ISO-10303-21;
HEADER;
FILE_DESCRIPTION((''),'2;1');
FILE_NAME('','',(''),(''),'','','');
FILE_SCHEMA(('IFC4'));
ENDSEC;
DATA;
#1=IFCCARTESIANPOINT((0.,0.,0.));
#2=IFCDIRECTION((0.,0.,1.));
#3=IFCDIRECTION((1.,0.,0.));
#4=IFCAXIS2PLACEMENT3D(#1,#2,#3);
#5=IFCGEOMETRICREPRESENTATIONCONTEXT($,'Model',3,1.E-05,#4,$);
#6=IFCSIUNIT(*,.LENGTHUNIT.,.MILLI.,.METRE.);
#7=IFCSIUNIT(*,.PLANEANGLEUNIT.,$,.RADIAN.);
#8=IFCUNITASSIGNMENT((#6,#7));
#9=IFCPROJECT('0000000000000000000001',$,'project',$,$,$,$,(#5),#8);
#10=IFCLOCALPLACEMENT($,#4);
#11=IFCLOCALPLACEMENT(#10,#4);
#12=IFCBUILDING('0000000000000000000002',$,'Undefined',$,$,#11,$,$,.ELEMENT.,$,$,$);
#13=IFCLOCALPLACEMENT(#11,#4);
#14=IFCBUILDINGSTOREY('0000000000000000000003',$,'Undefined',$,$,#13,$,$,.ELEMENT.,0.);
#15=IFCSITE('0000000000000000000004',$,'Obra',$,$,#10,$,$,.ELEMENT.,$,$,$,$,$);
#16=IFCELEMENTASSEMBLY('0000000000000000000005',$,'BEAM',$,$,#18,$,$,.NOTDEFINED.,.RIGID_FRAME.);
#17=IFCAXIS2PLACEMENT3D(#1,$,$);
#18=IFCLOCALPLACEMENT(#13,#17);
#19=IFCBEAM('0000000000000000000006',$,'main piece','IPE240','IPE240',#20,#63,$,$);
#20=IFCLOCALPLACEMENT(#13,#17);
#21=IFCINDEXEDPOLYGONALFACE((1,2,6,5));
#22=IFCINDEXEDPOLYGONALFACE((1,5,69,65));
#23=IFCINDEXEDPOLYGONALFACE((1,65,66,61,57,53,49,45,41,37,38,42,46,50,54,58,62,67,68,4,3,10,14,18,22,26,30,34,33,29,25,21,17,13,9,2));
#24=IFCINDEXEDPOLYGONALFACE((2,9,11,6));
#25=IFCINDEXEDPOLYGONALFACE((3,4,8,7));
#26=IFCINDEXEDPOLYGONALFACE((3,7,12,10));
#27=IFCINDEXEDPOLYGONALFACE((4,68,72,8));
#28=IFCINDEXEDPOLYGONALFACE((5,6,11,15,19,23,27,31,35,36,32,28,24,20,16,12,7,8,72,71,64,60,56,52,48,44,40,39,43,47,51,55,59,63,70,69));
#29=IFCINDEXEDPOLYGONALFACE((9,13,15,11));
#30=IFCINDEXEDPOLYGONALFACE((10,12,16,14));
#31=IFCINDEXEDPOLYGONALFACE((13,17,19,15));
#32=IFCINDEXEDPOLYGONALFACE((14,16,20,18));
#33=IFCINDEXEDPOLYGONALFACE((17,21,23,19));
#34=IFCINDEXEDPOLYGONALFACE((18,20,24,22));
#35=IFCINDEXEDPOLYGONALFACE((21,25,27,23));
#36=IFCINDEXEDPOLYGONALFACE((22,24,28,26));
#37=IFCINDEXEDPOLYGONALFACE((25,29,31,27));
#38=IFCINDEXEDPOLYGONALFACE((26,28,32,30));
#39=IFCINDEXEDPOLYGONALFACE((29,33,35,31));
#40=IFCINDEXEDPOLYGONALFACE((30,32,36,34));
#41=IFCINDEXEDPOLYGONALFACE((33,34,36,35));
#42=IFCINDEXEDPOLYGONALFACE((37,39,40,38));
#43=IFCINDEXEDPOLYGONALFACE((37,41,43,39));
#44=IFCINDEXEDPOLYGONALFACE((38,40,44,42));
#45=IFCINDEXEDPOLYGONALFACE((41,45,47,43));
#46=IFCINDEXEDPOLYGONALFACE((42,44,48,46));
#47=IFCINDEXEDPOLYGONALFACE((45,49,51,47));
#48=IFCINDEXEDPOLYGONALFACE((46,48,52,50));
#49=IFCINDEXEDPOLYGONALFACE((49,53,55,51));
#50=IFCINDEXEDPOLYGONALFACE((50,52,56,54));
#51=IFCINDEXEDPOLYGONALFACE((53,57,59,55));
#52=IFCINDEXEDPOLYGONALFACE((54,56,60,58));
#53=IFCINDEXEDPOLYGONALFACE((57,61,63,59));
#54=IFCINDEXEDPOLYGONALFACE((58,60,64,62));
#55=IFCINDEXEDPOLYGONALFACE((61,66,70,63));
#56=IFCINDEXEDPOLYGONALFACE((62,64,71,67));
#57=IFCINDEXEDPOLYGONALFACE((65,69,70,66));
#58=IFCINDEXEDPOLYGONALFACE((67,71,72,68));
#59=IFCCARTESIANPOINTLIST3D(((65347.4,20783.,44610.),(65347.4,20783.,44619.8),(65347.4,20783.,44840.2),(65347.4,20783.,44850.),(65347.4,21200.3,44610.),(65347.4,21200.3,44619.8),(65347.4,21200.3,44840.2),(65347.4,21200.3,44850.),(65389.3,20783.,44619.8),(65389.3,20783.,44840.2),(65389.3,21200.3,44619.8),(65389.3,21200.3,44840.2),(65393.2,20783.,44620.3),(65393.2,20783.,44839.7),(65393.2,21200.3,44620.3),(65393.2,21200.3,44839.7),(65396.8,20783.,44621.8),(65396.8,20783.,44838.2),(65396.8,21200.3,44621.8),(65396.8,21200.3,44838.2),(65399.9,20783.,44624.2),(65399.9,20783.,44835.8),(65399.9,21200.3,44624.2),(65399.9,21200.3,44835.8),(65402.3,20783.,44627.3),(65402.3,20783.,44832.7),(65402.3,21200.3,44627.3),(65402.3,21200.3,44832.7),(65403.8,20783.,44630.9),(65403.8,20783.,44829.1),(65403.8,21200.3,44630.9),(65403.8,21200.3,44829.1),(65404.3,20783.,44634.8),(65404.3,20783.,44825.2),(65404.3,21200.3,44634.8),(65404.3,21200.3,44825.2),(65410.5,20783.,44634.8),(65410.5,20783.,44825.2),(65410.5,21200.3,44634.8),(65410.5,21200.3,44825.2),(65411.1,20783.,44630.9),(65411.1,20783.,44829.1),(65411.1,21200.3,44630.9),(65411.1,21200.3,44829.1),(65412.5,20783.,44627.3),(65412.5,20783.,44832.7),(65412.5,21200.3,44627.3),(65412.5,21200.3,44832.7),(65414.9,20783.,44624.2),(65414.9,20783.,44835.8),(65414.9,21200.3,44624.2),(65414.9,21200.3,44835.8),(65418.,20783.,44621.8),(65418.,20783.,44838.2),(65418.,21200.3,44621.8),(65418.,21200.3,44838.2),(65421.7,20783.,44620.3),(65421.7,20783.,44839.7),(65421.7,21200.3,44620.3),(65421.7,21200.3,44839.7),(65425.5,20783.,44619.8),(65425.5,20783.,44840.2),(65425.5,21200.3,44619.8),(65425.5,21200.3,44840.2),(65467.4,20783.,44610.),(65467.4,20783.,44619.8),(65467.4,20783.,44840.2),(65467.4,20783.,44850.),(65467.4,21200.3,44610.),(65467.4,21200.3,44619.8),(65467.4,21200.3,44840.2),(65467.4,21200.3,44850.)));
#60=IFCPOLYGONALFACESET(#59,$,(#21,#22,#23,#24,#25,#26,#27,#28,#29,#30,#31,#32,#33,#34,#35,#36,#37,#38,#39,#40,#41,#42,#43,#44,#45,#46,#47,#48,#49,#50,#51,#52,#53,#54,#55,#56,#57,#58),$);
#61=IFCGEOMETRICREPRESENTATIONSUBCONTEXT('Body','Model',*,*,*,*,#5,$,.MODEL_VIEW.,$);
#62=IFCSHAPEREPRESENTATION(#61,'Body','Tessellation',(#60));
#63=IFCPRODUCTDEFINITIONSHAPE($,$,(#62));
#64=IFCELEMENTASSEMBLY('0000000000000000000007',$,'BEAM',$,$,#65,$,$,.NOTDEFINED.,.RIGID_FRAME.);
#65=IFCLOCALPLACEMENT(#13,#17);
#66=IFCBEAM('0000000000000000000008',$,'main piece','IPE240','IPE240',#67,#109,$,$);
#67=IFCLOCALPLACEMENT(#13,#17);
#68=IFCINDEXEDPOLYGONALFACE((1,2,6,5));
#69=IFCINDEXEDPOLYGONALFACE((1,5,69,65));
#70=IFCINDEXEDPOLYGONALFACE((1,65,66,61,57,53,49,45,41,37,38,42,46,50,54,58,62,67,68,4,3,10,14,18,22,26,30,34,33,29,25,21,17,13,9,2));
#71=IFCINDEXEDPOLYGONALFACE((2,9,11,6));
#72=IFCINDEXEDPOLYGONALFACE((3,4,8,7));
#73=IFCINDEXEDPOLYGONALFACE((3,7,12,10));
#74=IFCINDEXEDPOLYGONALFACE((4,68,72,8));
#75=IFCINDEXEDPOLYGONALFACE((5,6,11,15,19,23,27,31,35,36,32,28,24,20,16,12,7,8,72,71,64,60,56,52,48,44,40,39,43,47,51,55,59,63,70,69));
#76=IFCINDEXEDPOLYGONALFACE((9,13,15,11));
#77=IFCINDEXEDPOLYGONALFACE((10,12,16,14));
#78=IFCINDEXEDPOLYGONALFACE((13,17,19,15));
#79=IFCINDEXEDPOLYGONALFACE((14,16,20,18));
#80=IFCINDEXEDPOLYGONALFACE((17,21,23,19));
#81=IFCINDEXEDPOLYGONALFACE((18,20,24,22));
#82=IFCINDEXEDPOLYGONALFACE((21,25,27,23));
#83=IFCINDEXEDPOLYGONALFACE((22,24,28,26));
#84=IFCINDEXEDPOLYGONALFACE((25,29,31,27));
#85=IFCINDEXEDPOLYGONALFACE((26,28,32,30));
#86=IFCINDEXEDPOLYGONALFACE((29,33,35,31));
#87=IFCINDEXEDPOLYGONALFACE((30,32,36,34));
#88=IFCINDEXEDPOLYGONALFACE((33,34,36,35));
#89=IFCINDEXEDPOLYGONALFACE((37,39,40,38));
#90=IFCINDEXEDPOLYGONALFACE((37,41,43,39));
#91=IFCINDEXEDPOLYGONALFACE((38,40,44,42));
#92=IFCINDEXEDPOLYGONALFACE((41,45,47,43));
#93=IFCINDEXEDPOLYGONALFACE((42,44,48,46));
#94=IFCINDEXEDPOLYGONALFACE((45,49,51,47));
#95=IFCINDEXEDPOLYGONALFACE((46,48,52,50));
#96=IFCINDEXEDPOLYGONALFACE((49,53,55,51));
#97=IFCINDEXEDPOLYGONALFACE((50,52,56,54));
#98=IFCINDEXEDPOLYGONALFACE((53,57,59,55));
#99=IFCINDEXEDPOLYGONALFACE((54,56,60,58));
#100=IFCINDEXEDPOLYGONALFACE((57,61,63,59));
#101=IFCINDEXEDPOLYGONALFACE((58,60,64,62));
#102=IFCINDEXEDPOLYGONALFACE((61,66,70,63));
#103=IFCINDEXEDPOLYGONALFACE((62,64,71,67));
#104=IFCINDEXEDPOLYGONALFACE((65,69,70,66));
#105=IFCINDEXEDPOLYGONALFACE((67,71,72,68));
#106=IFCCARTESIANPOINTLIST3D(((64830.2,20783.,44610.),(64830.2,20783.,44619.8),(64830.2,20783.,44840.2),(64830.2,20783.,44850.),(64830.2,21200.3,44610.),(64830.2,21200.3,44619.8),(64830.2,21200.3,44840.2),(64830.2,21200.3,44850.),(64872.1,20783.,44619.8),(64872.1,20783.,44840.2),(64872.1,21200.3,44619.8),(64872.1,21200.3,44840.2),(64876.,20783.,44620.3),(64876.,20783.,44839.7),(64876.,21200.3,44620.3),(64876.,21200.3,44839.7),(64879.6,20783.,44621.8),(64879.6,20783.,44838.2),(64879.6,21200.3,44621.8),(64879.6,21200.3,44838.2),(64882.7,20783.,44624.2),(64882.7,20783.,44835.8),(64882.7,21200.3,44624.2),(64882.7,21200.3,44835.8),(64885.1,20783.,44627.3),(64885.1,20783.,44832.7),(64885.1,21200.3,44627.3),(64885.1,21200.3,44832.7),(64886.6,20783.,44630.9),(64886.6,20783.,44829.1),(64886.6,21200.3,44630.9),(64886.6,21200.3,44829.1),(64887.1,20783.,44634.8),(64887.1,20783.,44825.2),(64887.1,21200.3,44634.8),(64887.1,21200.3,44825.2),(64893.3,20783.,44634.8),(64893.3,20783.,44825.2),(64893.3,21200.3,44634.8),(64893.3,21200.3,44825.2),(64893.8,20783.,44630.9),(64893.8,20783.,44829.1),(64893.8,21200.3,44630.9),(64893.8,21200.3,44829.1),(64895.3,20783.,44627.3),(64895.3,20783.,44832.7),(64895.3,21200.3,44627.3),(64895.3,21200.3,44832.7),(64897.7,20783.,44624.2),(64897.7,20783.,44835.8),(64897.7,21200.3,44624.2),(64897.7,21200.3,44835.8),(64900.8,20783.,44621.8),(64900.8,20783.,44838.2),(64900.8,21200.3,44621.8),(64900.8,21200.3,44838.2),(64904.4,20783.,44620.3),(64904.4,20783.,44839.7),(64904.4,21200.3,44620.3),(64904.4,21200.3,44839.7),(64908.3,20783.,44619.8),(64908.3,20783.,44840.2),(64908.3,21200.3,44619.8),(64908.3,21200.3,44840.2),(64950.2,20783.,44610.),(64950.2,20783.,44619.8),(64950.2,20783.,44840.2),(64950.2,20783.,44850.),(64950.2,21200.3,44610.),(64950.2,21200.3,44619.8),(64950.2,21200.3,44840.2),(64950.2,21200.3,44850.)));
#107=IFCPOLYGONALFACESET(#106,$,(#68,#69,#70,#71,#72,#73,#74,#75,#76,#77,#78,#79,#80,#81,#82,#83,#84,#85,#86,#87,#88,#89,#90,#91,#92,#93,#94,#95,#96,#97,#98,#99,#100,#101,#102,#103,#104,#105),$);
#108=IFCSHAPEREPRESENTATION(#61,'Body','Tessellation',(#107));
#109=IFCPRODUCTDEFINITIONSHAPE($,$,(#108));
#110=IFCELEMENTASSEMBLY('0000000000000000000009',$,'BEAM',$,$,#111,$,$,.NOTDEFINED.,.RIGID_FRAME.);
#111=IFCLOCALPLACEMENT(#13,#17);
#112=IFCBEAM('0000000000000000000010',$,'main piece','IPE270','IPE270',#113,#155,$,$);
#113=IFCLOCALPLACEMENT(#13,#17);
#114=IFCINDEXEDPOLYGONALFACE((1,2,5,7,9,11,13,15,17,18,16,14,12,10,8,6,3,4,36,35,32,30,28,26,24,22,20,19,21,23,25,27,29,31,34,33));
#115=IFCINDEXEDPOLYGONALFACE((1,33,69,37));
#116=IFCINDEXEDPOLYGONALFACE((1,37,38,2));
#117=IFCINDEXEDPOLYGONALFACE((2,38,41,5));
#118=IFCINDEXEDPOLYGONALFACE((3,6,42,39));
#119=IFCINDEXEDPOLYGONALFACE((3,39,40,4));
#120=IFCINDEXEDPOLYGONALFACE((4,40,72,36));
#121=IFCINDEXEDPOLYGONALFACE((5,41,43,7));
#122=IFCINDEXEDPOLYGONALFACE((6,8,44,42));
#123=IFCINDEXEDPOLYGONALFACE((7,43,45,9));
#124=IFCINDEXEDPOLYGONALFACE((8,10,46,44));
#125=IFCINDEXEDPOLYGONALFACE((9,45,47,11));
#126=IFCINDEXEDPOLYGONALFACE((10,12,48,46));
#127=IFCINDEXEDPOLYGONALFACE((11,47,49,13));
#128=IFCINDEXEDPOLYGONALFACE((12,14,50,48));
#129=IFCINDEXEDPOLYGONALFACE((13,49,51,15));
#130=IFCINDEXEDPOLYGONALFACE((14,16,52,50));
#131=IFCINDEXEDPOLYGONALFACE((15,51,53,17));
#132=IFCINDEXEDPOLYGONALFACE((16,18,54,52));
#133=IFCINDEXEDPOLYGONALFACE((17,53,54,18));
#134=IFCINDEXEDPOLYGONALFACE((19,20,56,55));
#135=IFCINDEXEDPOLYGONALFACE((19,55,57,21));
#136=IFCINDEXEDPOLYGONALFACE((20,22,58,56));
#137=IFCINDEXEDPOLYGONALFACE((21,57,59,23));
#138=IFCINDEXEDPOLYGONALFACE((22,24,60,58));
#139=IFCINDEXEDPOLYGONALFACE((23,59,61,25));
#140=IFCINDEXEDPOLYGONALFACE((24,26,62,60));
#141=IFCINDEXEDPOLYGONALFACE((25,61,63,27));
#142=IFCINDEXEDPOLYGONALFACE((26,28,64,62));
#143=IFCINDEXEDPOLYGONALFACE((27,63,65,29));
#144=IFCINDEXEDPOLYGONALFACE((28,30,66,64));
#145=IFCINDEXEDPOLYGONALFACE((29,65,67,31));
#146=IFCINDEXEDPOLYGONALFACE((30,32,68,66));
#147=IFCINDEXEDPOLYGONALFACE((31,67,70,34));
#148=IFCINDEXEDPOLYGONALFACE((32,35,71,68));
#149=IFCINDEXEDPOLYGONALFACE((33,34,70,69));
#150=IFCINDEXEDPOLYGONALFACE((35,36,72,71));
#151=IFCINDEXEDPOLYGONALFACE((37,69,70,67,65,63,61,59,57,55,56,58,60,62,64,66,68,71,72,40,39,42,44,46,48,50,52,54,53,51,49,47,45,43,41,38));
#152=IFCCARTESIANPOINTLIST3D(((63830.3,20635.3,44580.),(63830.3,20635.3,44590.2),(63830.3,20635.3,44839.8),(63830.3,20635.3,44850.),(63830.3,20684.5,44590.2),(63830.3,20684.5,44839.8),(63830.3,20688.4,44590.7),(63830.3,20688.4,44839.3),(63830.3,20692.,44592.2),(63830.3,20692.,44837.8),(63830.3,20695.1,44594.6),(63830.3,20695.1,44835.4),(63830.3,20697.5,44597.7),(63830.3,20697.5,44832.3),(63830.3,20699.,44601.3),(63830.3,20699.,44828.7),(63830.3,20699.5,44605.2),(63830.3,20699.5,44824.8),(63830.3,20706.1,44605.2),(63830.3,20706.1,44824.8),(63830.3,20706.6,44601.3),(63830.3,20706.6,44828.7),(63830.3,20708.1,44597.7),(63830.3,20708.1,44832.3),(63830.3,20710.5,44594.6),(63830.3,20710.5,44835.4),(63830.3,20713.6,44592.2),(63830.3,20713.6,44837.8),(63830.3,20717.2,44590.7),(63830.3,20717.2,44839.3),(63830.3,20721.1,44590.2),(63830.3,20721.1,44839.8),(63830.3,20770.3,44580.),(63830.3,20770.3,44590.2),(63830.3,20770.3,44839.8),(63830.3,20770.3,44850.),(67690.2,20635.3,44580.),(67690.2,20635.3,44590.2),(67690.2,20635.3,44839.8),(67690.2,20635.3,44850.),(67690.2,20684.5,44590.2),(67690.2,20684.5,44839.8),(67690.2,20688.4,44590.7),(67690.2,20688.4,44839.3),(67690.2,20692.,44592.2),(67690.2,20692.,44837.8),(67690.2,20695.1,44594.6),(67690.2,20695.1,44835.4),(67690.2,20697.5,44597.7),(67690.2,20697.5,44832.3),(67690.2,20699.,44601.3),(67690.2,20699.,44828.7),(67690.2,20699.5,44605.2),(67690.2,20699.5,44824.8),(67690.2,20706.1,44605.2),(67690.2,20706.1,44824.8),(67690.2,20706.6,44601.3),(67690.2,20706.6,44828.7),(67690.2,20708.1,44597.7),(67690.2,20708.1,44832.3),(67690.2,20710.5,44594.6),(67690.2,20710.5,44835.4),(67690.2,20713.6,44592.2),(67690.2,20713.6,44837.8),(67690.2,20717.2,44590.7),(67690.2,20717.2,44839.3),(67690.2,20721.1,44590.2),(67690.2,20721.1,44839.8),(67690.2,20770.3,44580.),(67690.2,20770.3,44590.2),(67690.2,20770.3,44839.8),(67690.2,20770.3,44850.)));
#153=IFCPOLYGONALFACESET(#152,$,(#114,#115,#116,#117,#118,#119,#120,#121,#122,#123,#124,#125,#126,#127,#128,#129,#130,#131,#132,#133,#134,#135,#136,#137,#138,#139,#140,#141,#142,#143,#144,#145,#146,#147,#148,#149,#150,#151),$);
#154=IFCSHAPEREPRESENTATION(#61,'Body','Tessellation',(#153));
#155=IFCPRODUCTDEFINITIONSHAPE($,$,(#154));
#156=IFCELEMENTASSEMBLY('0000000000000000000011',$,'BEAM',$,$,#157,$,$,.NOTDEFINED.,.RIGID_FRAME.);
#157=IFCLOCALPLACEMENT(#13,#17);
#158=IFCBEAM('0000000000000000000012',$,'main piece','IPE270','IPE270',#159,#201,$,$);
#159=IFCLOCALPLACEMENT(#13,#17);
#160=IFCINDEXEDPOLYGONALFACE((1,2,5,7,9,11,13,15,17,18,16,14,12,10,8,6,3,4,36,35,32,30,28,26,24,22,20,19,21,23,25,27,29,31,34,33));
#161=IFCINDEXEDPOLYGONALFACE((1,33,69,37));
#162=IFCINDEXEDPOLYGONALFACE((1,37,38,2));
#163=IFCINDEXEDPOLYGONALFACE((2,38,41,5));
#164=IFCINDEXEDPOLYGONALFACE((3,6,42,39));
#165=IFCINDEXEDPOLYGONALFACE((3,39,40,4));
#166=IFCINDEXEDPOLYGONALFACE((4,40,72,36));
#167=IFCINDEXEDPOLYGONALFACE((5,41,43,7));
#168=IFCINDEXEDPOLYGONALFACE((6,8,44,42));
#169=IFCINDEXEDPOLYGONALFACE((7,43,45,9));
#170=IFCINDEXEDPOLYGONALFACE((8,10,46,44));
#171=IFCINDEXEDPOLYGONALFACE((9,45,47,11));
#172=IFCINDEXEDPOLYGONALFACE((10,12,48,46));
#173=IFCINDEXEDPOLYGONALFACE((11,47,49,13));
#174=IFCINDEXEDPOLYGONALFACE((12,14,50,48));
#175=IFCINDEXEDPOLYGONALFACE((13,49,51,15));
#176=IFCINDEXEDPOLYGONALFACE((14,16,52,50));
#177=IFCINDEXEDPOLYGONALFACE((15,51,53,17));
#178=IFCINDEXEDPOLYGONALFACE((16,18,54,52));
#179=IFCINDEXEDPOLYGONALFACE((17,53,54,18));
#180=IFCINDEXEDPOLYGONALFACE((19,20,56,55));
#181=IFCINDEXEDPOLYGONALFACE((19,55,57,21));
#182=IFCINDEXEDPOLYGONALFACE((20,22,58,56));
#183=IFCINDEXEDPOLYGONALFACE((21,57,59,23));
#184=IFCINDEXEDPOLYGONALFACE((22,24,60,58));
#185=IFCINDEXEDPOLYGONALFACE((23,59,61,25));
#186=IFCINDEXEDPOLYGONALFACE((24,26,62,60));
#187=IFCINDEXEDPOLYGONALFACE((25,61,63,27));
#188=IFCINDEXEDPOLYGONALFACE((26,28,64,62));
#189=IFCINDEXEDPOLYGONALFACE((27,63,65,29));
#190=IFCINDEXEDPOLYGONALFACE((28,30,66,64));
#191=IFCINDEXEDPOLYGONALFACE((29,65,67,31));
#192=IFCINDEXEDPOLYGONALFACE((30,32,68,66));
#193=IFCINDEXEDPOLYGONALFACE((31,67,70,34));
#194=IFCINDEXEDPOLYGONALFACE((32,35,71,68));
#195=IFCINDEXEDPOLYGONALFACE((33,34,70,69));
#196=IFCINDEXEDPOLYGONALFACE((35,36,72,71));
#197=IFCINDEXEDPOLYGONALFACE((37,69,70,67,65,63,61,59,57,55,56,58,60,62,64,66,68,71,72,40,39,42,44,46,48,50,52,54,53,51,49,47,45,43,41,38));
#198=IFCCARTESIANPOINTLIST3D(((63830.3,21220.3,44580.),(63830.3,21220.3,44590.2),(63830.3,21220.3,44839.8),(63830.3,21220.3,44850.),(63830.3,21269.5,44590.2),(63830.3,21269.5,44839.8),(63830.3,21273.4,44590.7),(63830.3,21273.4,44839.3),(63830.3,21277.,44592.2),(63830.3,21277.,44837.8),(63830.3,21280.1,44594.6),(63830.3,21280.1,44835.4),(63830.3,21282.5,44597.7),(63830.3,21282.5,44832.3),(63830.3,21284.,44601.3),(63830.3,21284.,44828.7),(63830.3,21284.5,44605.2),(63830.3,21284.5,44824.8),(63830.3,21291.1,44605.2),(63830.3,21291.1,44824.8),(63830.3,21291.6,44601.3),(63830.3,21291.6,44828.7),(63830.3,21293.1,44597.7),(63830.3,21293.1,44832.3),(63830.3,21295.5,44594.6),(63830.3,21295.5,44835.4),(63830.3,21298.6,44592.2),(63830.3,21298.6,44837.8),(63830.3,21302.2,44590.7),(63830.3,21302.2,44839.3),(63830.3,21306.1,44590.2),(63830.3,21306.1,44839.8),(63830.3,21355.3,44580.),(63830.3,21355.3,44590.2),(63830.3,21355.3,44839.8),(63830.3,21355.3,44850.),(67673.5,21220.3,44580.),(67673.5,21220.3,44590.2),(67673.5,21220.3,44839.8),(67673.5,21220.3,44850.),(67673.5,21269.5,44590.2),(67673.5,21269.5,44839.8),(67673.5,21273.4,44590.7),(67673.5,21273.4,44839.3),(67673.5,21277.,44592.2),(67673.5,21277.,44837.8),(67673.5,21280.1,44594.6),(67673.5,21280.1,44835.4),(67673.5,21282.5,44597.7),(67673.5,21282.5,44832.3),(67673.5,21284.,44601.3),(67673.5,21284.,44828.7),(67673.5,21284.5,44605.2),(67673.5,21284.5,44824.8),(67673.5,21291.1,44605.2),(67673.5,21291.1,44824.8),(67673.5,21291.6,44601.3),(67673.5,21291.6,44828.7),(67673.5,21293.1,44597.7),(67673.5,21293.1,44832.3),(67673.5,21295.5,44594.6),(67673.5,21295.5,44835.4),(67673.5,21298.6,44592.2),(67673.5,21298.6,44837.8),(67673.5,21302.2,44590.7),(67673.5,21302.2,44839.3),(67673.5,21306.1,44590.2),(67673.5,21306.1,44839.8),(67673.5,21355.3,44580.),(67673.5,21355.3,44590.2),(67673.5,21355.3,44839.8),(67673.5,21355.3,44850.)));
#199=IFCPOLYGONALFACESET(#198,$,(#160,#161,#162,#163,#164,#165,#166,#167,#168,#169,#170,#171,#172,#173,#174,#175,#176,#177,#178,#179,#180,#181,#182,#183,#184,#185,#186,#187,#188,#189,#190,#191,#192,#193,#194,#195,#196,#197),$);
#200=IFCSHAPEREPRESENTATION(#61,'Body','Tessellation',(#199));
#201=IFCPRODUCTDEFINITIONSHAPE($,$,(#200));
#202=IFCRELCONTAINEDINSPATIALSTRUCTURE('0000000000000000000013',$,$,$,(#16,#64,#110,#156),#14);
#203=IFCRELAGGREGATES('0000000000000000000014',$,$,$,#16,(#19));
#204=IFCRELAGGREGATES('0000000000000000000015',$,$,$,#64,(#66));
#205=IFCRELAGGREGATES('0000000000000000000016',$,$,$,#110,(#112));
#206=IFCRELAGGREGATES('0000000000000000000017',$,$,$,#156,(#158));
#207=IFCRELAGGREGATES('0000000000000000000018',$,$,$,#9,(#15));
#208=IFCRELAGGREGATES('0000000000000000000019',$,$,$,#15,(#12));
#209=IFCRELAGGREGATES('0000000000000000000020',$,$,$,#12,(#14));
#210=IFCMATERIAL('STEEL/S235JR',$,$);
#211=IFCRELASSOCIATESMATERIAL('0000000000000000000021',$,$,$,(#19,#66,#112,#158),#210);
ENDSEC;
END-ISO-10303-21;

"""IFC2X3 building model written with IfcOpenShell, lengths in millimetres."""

from ifc_helpers import new_model, si_unit, frame, origin_with_axes, origin_2d_with_axis, place, context, subcontext, project, spatial, i_section, extrude, material, element, aggregate, save


model = new_model("IFC2X3")

# Units and contexts
model_context = context("Model", 3, precision=1e-05, world=origin_with_axes())
body_context = subcontext(model_context, "Body", "Model", "MODEL_VIEW")
ifc_project = project(units=[si_unit("LENGTHUNIT", "METRE", prefix="MILLI"), si_unit("PLANEANGLEUNIT", "RADIAN")], contexts=[model_context])

# Site, building, storey
site_placement = place(None, origin_with_axes())
site = spatial("IfcSite", under=ifc_project, at=site_placement, Name="Obra", CompositionType="ELEMENT")
building_placement = place(site_placement, origin_with_axes())
building = spatial("IfcBuilding", under=site, at=building_placement, Name="Undefined", CompositionType="ELEMENT")
storey_placement = place(building_placement, origin_with_axes())
storey = spatial("IfcBuildingStorey", under=building, at=storey_placement, Name="Undefined", CompositionType="ELEMENT", Elevation=0.0)

# Shared definitions
ifc_material_1 = material(Name="STEEL/S235JR")

# Element assemblies, beams
assembly_1_placement = place(storey_placement, origin_with_axes())
assembly_1 = element("IfcElementAssembly", 1, at=assembly_1_placement, inside=storey, Name="BEAM", AssemblyPlace="NOTDEFINED", PredefinedType="RIGID_FRAME")
beam_1_placement = place(assembly_1_placement, frame((65407.4, 20783.0, 44730.0), z_axis=(0.0, 0.0, 1.0), x_axis=(0.0, 1.0, 0.0)))
beam_1 = element("IfcBeam", 2, at=beam_1_placement, material=ifc_material_1, Name="main piece", Description="IPE240", ObjectType="IPE240", context=body_context, shape_type="SweptSolid", body=[
    extrude(i_section(OverallWidth=120.0, OverallDepth=240.0, WebThickness=6.2, FlangeThickness=9.8, FilletRadius=15.0, at=origin_2d_with_axis()), frame((417.2, 0.0, 0.0), z_axis=(-1.0, 0.0, 0.0), x_axis=(0.0, -1.0, 0.0)), (0.0, 0.0, 1.0), 417.2),
])
aggregate(assembly_1, [beam_1])
assembly_2_placement = place(storey_placement, origin_with_axes())
assembly_2 = element("IfcElementAssembly", 3, at=assembly_2_placement, inside=storey, Name="BEAM", AssemblyPlace="NOTDEFINED", PredefinedType="RIGID_FRAME")
beam_2_placement = place(assembly_2_placement, frame((64890.2, 20783.0, 44730.0), z_axis=(0.0, 0.0, 1.0), x_axis=(0.0, 1.0, 0.0)))
beam_2 = element("IfcBeam", 4, at=beam_2_placement, material=ifc_material_1, Name="main piece", Description="IPE240", ObjectType="IPE240", context=body_context, shape_type="SweptSolid", body=[
    extrude(i_section(OverallWidth=120.0, OverallDepth=240.0, WebThickness=6.2, FlangeThickness=9.8, FilletRadius=15.0, at=origin_2d_with_axis()), frame((417.2, 0.0, 0.0), z_axis=(-1.0, 0.0, 0.0), x_axis=(0.0, -1.0, 0.0)), (0.0, 0.0, 1.0), 417.2),
])
aggregate(assembly_2, [beam_2])
assembly_3_placement = place(storey_placement, origin_with_axes())
assembly_3 = element("IfcElementAssembly", 5, at=assembly_3_placement, inside=storey, Name="BEAM", AssemblyPlace="NOTDEFINED", PredefinedType="RIGID_FRAME")
beam_3_placement = place(assembly_3_placement, frame((63830.3, 20702.8, 44715.0), z_axis=(0.0, 0.0, 1.0), x_axis=(1.0, 0.000002, 0.0)))
beam_3 = element("IfcBeam", 6, at=beam_3_placement, material=ifc_material_1, Name="main piece", Description="IPE270", ObjectType="IPE270", context=body_context, shape_type="SweptSolid", body=[
    extrude(i_section(OverallWidth=135.0, OverallDepth=270.0, WebThickness=6.6, FlangeThickness=10.2, FilletRadius=15.0, at=origin_2d_with_axis()), frame((3859.9, 0.0, 0.0), z_axis=(-1.0, 0.0, 0.0), x_axis=(0.0, -1.0, 0.0)), (0.0, 0.0, 1.0), 3859.9),
])
aggregate(assembly_3, [beam_3])
assembly_4_placement = place(storey_placement, origin_with_axes())
assembly_4 = element("IfcElementAssembly", 7, at=assembly_4_placement, inside=storey, Name="BEAM", AssemblyPlace="NOTDEFINED", PredefinedType="RIGID_FRAME")
beam_4_placement = place(assembly_4_placement, frame((63830.3, 21287.8, 44715.0), z_axis=(0.0, 0.0, 1.0), x_axis=(1.0, 0.000002, 0.0)))
beam_4 = element("IfcBeam", 8, at=beam_4_placement, material=ifc_material_1, Name="main piece", Description="IPE270", ObjectType="IPE270", context=body_context, shape_type="SweptSolid", body=[
    extrude(i_section(OverallWidth=135.0, OverallDepth=270.0, WebThickness=6.6, FlangeThickness=10.2, FilletRadius=15.0, at=origin_2d_with_axis()), frame((3843.2, 0.0, 0.0), z_axis=(-1.0, 0.0, 0.0), x_axis=(0.0, -1.0, 0.0)), (0.0, 0.0, 1.0), 3843.2),
])
aggregate(assembly_4, [beam_4])

save(model, "model.ifc")
